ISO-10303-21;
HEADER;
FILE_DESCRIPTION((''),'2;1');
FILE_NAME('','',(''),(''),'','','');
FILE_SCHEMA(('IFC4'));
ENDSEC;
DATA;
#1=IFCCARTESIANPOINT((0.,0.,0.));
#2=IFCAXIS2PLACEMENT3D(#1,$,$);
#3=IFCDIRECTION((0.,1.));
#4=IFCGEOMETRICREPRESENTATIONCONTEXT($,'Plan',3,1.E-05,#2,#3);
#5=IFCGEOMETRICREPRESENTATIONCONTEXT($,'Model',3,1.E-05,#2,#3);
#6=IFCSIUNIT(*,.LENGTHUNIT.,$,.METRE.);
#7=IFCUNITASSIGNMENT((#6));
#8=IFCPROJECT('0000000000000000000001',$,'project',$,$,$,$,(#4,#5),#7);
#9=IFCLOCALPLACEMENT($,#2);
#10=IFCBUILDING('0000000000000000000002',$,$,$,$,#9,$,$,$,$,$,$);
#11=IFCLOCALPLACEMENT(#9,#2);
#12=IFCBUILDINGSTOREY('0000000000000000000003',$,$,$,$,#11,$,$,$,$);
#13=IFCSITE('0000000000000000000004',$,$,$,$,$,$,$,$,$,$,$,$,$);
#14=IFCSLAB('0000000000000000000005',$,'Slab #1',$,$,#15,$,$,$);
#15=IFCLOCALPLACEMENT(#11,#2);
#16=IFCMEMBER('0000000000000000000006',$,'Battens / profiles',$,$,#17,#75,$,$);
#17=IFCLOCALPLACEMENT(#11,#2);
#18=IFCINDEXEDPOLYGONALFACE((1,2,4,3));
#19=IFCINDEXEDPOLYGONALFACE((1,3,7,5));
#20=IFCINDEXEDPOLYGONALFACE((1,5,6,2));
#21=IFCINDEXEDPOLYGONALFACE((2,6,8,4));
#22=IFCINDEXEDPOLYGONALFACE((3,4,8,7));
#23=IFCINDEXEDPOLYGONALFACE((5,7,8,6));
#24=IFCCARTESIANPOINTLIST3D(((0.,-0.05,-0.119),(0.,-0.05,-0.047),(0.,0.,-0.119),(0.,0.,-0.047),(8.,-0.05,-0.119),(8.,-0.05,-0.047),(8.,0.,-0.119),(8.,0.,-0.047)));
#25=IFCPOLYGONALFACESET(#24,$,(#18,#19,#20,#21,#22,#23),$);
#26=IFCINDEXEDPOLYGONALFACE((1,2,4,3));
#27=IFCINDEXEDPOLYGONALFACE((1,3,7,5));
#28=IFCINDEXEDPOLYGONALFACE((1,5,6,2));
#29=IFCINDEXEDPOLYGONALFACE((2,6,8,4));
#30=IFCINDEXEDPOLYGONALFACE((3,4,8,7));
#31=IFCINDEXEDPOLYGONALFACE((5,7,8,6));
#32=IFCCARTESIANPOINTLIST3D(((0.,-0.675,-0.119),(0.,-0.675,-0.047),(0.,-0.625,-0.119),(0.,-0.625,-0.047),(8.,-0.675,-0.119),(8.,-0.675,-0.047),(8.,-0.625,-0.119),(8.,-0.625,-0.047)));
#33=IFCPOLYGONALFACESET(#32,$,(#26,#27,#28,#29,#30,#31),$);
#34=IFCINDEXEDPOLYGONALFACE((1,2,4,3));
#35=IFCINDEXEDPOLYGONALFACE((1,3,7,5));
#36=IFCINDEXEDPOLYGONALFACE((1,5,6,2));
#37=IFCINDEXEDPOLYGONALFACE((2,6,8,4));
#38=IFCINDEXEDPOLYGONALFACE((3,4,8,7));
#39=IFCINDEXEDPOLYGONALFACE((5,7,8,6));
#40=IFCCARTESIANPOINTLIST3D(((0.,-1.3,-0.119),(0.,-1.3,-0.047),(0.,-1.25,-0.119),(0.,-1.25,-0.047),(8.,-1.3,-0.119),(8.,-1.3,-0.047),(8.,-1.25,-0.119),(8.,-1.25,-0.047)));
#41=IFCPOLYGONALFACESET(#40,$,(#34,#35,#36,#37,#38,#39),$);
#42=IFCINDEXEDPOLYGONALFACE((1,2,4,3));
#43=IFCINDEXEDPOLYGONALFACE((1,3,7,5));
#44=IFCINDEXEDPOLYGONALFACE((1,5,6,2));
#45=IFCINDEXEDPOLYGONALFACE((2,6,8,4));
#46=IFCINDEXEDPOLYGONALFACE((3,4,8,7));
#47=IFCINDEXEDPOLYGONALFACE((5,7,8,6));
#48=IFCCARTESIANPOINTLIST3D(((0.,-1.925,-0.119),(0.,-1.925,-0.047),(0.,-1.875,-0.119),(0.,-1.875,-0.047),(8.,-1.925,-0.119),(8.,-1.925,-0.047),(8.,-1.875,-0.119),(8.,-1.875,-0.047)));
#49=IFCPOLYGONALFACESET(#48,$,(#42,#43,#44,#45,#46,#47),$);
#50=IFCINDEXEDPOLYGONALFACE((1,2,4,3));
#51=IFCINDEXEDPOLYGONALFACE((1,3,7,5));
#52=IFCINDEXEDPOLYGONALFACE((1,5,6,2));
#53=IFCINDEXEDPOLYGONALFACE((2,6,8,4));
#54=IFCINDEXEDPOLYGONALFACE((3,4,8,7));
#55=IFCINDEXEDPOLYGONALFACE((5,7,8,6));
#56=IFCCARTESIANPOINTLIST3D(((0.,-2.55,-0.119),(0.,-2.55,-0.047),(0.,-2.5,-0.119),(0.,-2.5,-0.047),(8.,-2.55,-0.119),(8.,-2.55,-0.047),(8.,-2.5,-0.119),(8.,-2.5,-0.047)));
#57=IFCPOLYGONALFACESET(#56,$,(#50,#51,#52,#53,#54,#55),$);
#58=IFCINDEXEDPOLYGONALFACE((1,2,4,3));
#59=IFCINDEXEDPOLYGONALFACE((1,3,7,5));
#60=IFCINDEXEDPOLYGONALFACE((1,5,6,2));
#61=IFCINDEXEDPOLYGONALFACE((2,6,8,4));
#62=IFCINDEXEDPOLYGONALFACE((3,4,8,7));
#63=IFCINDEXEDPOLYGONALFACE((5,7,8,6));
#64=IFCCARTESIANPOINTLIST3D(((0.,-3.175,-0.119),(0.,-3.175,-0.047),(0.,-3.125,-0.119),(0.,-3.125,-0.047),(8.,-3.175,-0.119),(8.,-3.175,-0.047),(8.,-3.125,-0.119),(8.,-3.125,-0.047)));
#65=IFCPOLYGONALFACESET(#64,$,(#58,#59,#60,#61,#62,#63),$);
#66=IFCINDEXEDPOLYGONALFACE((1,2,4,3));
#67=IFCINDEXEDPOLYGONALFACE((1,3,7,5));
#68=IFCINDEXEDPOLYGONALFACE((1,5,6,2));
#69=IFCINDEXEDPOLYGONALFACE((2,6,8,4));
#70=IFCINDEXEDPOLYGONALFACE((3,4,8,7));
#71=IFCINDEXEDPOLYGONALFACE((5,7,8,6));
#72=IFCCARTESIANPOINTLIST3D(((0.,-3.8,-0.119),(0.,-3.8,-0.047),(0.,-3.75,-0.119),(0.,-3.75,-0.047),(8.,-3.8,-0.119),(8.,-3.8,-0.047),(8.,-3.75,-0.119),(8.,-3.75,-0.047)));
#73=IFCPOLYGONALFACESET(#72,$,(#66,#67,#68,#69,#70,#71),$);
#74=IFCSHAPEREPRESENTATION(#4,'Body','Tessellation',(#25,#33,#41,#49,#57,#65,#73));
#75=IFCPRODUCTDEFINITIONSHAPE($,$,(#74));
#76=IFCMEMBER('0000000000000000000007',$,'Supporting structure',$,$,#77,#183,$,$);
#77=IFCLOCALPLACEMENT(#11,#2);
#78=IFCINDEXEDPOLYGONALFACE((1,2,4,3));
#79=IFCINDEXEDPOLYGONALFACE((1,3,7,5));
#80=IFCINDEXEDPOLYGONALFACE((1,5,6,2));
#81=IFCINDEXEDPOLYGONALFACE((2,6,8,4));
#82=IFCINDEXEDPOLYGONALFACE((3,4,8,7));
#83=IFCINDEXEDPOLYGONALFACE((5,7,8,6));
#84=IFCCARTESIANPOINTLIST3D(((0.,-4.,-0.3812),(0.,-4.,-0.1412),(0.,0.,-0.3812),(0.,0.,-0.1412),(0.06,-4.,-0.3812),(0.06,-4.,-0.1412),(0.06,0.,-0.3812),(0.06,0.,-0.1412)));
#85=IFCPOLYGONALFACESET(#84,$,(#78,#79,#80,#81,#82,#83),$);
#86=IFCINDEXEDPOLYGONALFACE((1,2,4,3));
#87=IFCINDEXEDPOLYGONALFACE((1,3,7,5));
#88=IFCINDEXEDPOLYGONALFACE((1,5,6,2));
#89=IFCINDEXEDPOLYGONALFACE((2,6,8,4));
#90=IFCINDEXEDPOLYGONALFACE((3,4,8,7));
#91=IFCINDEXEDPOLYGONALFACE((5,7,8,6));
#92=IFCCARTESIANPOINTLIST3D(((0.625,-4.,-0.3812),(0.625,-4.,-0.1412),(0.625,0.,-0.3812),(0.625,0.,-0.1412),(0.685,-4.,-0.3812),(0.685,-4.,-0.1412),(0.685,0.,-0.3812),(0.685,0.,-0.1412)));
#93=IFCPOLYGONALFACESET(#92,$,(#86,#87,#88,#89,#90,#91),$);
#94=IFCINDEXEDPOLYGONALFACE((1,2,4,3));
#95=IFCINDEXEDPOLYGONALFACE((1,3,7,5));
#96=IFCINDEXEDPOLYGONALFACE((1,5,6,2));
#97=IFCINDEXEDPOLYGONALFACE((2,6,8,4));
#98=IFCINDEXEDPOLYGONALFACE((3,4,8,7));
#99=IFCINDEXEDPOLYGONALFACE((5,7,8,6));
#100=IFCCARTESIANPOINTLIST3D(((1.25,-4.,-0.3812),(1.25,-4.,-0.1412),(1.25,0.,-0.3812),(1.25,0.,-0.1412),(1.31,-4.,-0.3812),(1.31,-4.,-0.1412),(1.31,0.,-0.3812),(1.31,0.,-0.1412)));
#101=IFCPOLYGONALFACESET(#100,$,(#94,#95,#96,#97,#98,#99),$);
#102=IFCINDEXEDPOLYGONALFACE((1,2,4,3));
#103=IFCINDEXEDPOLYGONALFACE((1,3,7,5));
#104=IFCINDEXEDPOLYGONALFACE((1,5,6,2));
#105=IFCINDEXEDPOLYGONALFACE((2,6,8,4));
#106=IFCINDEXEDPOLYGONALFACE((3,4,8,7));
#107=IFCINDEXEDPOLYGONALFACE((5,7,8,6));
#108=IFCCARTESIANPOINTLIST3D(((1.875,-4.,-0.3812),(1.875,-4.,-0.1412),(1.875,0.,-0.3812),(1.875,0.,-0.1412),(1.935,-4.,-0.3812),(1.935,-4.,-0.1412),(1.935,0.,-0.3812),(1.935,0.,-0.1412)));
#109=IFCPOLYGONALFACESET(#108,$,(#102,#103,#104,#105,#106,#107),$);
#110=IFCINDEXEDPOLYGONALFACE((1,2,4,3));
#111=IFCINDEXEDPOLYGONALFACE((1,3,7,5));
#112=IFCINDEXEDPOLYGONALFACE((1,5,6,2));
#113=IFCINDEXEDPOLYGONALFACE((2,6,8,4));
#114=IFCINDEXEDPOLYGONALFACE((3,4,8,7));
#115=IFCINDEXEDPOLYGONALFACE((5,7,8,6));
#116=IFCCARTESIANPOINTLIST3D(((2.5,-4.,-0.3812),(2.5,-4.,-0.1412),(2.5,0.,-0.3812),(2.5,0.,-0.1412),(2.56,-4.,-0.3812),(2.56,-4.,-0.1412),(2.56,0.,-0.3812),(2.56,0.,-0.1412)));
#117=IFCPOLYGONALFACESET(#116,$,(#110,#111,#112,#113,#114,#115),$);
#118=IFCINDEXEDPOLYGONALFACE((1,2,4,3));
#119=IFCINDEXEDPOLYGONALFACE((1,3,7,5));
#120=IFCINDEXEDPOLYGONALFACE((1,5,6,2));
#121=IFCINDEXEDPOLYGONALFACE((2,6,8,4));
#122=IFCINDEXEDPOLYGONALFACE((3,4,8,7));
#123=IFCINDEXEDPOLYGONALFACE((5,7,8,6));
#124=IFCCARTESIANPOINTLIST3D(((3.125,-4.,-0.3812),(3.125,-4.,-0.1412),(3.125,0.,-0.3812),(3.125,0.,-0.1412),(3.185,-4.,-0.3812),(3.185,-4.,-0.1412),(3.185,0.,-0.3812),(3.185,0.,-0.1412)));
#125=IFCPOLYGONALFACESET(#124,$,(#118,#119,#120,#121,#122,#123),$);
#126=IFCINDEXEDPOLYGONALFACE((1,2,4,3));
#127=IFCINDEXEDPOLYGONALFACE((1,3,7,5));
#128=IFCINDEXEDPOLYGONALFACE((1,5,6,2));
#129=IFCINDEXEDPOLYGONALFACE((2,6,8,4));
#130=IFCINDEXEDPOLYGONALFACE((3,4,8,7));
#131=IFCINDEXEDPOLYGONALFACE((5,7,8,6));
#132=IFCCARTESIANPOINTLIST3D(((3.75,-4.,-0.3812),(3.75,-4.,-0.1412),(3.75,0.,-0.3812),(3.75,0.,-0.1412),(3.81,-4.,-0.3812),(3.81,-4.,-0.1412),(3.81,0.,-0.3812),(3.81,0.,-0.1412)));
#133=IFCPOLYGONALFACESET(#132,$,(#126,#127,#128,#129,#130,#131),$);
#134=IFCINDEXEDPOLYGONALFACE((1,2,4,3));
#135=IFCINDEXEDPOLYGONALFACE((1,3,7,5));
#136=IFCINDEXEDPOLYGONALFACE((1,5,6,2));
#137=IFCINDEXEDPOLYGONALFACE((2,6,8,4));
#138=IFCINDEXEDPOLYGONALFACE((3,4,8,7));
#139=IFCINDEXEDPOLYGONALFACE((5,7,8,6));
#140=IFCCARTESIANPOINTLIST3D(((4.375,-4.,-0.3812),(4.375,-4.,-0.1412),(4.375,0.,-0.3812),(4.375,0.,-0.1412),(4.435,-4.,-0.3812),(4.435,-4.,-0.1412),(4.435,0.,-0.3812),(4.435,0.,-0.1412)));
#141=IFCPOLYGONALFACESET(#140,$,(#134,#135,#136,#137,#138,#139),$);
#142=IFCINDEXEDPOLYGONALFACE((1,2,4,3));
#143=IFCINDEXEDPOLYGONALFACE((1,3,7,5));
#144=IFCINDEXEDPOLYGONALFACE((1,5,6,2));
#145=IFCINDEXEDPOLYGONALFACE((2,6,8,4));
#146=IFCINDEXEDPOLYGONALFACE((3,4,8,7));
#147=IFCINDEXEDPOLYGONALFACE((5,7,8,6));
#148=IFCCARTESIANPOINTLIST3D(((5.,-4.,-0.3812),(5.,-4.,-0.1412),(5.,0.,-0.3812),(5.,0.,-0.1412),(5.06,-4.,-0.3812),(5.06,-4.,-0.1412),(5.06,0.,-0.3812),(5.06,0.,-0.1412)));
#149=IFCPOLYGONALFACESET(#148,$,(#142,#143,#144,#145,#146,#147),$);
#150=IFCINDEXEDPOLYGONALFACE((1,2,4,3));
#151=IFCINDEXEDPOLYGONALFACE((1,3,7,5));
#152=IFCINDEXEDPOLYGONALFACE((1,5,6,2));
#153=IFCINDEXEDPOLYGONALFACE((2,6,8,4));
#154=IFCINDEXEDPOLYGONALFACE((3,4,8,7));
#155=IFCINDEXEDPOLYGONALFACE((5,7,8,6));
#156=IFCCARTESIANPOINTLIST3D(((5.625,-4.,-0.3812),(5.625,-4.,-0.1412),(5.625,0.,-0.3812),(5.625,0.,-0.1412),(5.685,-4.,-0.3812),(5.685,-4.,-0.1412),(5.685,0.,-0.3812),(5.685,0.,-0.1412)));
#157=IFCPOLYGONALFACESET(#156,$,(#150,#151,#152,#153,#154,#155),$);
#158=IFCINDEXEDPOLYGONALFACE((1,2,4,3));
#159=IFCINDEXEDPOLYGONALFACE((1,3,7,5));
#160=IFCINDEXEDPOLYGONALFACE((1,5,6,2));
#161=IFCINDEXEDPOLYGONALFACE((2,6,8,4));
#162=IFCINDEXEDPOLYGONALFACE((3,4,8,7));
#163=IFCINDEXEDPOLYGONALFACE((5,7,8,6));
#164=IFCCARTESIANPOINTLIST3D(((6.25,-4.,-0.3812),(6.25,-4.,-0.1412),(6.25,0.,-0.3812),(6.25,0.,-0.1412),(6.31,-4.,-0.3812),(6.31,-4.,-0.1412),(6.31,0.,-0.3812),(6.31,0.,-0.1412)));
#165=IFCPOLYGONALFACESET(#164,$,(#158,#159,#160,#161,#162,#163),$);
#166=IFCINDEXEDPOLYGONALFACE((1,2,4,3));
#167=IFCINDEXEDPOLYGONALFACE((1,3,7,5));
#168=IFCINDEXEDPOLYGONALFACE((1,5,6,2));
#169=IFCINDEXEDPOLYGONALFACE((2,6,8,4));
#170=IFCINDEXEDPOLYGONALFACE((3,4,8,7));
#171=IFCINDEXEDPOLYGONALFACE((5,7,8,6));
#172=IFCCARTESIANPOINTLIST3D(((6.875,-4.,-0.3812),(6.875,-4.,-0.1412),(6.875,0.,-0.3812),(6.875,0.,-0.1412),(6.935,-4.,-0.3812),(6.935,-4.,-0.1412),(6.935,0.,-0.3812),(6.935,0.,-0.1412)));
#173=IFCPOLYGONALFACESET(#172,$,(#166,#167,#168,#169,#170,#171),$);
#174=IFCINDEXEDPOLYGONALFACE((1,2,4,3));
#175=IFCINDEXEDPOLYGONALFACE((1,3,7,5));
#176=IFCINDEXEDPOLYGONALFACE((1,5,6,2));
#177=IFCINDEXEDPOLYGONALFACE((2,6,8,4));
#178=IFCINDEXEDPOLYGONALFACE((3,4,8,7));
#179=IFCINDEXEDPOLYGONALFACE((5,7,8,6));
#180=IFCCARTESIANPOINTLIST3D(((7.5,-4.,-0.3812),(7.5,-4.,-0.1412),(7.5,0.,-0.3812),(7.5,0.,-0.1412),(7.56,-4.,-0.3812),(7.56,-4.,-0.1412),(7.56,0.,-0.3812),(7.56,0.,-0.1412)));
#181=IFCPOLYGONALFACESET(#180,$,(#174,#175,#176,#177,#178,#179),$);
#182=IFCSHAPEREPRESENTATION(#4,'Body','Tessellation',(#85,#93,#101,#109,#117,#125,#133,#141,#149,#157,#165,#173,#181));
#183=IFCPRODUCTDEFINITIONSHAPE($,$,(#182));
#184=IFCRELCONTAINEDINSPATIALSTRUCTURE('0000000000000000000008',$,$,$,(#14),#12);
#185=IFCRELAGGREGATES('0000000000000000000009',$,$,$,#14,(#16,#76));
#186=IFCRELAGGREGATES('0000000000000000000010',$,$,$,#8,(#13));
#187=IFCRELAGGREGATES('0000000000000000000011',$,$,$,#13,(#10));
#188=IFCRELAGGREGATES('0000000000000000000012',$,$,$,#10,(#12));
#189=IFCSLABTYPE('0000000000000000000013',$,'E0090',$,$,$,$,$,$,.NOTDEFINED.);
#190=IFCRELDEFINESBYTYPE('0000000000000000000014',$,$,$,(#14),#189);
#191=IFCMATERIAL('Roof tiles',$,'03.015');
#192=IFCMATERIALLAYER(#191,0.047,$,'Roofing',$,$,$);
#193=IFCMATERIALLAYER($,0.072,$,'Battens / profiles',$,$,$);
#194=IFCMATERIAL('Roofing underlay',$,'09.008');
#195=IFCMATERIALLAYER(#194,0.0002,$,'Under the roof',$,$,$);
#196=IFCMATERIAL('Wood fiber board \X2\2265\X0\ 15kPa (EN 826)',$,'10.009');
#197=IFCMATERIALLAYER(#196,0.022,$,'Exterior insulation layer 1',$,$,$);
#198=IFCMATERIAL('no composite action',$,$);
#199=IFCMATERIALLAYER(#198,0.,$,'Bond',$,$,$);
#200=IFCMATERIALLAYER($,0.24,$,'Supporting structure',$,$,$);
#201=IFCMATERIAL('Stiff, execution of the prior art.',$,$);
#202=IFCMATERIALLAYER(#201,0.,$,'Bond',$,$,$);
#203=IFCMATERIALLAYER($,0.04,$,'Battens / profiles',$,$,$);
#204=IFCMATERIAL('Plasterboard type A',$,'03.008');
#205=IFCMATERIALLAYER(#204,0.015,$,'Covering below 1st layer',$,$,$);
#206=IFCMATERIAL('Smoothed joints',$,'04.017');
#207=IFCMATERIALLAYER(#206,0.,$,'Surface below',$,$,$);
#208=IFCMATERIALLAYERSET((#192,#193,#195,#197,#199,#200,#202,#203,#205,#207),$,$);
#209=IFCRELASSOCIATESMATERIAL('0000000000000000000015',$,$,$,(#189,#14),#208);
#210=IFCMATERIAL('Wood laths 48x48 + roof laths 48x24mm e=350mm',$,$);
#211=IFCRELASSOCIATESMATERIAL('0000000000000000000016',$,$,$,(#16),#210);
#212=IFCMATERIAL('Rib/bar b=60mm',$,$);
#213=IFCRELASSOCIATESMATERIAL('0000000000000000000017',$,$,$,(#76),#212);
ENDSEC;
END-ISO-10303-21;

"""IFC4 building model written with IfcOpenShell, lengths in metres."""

from ifc_helpers import new_model, si_unit, direction, frame, frame_2d, origin, place, context, project, spatial, rectangle, extrude, material, layer, layer_set, type_object, element, aggregate, save


model = new_model("IFC4")

# Units and contexts
plan_context = context("Plan", 3, precision=1e-05, world=origin(), true_north=direction((0.0, 1.0)))
model_context = context("Model", 3, precision=1e-05, world=origin(), true_north=direction((0.0, 1.0)))
ifc_project = project(units=[si_unit("LENGTHUNIT", "METRE")], contexts=[plan_context, model_context])

# Site, building, storey
site = spatial("IfcSite", under=ifc_project)
building_placement = place(None, origin())
building = spatial("IfcBuilding", under=site, at=building_placement)
storey_placement = place(building_placement, origin())
storey = spatial("IfcBuildingStorey", under=building, at=storey_placement)

# Slab, members
ifc_material_1 = material(Name="Roof tiles", Category="03.015")
ifc_layer_1 = layer(ifc_material_1, 0.047, Name="Roofing")
ifc_layer_2 = layer(None, 0.072, Name="Battens / profiles")
ifc_material_2 = material(Name="Roofing underlay", Category="09.008")
ifc_layer_3 = layer(ifc_material_2, 0.0002, Name="Under the roof")
ifc_material_3 = material(Name="Wood fiber board ≥ 15kPa (EN 826)", Category="10.009")
ifc_layer_4 = layer(ifc_material_3, 0.022, Name="Exterior insulation layer 1")
ifc_material_4 = material(Name="no composite action")
ifc_layer_5 = layer(ifc_material_4, 0.0, Name="Bond")
ifc_layer_6 = layer(None, 0.24, Name="Supporting structure")
ifc_material_5 = material(Name="Stiff, execution of the prior art.")
ifc_layer_7 = layer(ifc_material_5, 0.0, Name="Bond")
ifc_layer_8 = layer(None, 0.04, Name="Battens / profiles")
ifc_material_6 = material(Name="Plasterboard type A", Category="03.008")
ifc_layer_9 = layer(ifc_material_6, 0.015, Name="Covering below 1st layer")
ifc_material_7 = material(Name="Smoothed joints", Category="04.017")
ifc_layer_10 = layer(ifc_material_7, 0.0, Name="Surface below")
ifc_layer_set = layer_set([ifc_layer_1, ifc_layer_2, ifc_layer_3, ifc_layer_4, ifc_layer_5, ifc_layer_6, ifc_layer_7, ifc_layer_8, ifc_layer_9, ifc_layer_10])
slab_type = type_object("IfcSlabType", Name="E0090", PredefinedType="NOTDEFINED", material=ifc_layer_set)
slab_placement = place(None, frame((0.0, 0.0, 0.0), z_axis=(0.0, 0.0, -1.0), x_axis=(1.0, 0.0, 0.0)))
slab = element("IfcSlab", 1, at=slab_placement, inside=storey, type_object=slab_type, material=ifc_layer_set, Name="Slab #1")
ifc_material_8 = material(Name="Wood laths 48x48 + roof laths 48x24mm e=350mm")
member_1_placement = place(slab_placement, origin())
member_1 = element("IfcMember", 2, at=member_1_placement, material=ifc_material_8, Name="Battens / profiles", context=plan_context, shape_type="SweptSolid", body=[
    extrude(rectangle(XDim=0.05, YDim=0.072, at=frame_2d((0.025, 0.036), x_axis=(1.0, 0.0))), frame((0.0, 0.0, 0.047), z_axis=(1.0, 0.0, 0.0), x_axis=(0.0, 1.0, 0.0)), (0.0, 0.0, 1.0), 8.0),
    extrude(rectangle(XDim=0.05, YDim=0.072, at=frame_2d((0.025, 0.036), x_axis=(1.0, 0.0))), frame((0.0, 0.625, 0.047), z_axis=(1.0, 0.0, 0.0), x_axis=(0.0, 1.0, 0.0)), (0.0, 0.0, 1.0), 8.0),
    extrude(rectangle(XDim=0.05, YDim=0.072, at=frame_2d((0.025, 0.036), x_axis=(1.0, 0.0))), frame((0.0, 1.25, 0.047), z_axis=(1.0, 0.0, 0.0), x_axis=(0.0, 1.0, 0.0)), (0.0, 0.0, 1.0), 8.0),
    extrude(rectangle(XDim=0.05, YDim=0.072, at=frame_2d((0.025, 0.036), x_axis=(1.0, 0.0))), frame((0.0, 1.875, 0.047), z_axis=(1.0, 0.0, 0.0), x_axis=(0.0, 1.0, 0.0)), (0.0, 0.0, 1.0), 8.0),
    extrude(rectangle(XDim=0.05, YDim=0.072, at=frame_2d((0.025, 0.036), x_axis=(1.0, 0.0))), frame((0.0, 2.5, 0.047), z_axis=(1.0, 0.0, 0.0), x_axis=(0.0, 1.0, 0.0)), (0.0, 0.0, 1.0), 8.0),
    extrude(rectangle(XDim=0.05, YDim=0.072, at=frame_2d((0.025, 0.036), x_axis=(1.0, 0.0))), frame((0.0, 3.125, 0.047), z_axis=(1.0, 0.0, 0.0), x_axis=(0.0, 1.0, 0.0)), (0.0, 0.0, 1.0), 8.0),
    extrude(rectangle(XDim=0.05, YDim=0.072, at=frame_2d((0.025, 0.036), x_axis=(1.0, 0.0))), frame((0.0, 3.75, 0.047), z_axis=(1.0, 0.0, 0.0), x_axis=(0.0, 1.0, 0.0)), (0.0, 0.0, 1.0), 8.0),
])
ifc_material_9 = material(Name="Rib/bar b=60mm")
member_2_placement = place(slab_placement, origin())
member_2 = element("IfcMember", 3, at=member_2_placement, material=ifc_material_9, Name="Supporting structure", context=plan_context, shape_type="SweptSolid", body=[
    extrude(rectangle(XDim=0.06, YDim=0.24, at=frame_2d((0.03, 0.12), x_axis=(1.0, 0.0))), frame((0.0, 4.0, 0.1412), z_axis=(0.0, -1.0, 0.0), x_axis=(1.0, 0.0, 0.0)), (0.0, 0.0, 1.0), 4.0),
    extrude(rectangle(XDim=0.06, YDim=0.24, at=frame_2d((0.03, 0.12), x_axis=(1.0, 0.0))), frame((0.625, 4.0, 0.1412), z_axis=(0.0, -1.0, 0.0), x_axis=(1.0, 0.0, 0.0)), (0.0, 0.0, 1.0), 4.0),
    extrude(rectangle(XDim=0.06, YDim=0.24, at=frame_2d((0.03, 0.12), x_axis=(1.0, 0.0))), frame((1.25, 4.0, 0.1412), z_axis=(0.0, -1.0, 0.0), x_axis=(1.0, 0.0, 0.0)), (0.0, 0.0, 1.0), 4.0),
    extrude(rectangle(XDim=0.06, YDim=0.24, at=frame_2d((0.03, 0.12), x_axis=(1.0, 0.0))), frame((1.875, 4.0, 0.1412), z_axis=(0.0, -1.0, 0.0), x_axis=(1.0, 0.0, 0.0)), (0.0, 0.0, 1.0), 4.0),
    extrude(rectangle(XDim=0.06, YDim=0.24, at=frame_2d((0.03, 0.12), x_axis=(1.0, 0.0))), frame((2.5, 4.0, 0.1412), z_axis=(0.0, -1.0, 0.0), x_axis=(1.0, 0.0, 0.0)), (0.0, 0.0, 1.0), 4.0),
    extrude(rectangle(XDim=0.06, YDim=0.24, at=frame_2d((0.03, 0.12), x_axis=(1.0, 0.0))), frame((3.125, 4.0, 0.1412), z_axis=(0.0, -1.0, 0.0), x_axis=(1.0, 0.0, 0.0)), (0.0, 0.0, 1.0), 4.0),
    extrude(rectangle(XDim=0.06, YDim=0.24, at=frame_2d((0.03, 0.12), x_axis=(1.0, 0.0))), frame((3.75, 4.0, 0.1412), z_axis=(0.0, -1.0, 0.0), x_axis=(1.0, 0.0, 0.0)), (0.0, 0.0, 1.0), 4.0),
    extrude(rectangle(XDim=0.06, YDim=0.24, at=frame_2d((0.03, 0.12), x_axis=(1.0, 0.0))), frame((4.375, 4.0, 0.1412), z_axis=(0.0, -1.0, 0.0), x_axis=(1.0, 0.0, 0.0)), (0.0, 0.0, 1.0), 4.0),
    extrude(rectangle(XDim=0.06, YDim=0.24, at=frame_2d((0.03, 0.12), x_axis=(1.0, 0.0))), frame((5.0, 4.0, 0.1412), z_axis=(0.0, -1.0, 0.0), x_axis=(1.0, 0.0, 0.0)), (0.0, 0.0, 1.0), 4.0),
    extrude(rectangle(XDim=0.06, YDim=0.24, at=frame_2d((0.03, 0.12), x_axis=(1.0, 0.0))), frame((5.625, 4.0, 0.1412), z_axis=(0.0, -1.0, 0.0), x_axis=(1.0, 0.0, 0.0)), (0.0, 0.0, 1.0), 4.0),
    extrude(rectangle(XDim=0.06, YDim=0.24, at=frame_2d((0.03, 0.12), x_axis=(1.0, 0.0))), frame((6.25, 4.0, 0.1412), z_axis=(0.0, -1.0, 0.0), x_axis=(1.0, 0.0, 0.0)), (0.0, 0.0, 1.0), 4.0),
    extrude(rectangle(XDim=0.06, YDim=0.24, at=frame_2d((0.03, 0.12), x_axis=(1.0, 0.0))), frame((6.875, 4.0, 0.1412), z_axis=(0.0, -1.0, 0.0), x_axis=(1.0, 0.0, 0.0)), (0.0, 0.0, 1.0), 4.0),
    extrude(rectangle(XDim=0.06, YDim=0.24, at=frame_2d((0.03, 0.12), x_axis=(1.0, 0.0))), frame((7.5, 4.0, 0.1412), z_axis=(0.0, -1.0, 0.0), x_axis=(1.0, 0.0, 0.0)), (0.0, 0.0, 1.0), 4.0),
])
aggregate(slab, [member_1, member_2])

save(model, "model.ifc")
